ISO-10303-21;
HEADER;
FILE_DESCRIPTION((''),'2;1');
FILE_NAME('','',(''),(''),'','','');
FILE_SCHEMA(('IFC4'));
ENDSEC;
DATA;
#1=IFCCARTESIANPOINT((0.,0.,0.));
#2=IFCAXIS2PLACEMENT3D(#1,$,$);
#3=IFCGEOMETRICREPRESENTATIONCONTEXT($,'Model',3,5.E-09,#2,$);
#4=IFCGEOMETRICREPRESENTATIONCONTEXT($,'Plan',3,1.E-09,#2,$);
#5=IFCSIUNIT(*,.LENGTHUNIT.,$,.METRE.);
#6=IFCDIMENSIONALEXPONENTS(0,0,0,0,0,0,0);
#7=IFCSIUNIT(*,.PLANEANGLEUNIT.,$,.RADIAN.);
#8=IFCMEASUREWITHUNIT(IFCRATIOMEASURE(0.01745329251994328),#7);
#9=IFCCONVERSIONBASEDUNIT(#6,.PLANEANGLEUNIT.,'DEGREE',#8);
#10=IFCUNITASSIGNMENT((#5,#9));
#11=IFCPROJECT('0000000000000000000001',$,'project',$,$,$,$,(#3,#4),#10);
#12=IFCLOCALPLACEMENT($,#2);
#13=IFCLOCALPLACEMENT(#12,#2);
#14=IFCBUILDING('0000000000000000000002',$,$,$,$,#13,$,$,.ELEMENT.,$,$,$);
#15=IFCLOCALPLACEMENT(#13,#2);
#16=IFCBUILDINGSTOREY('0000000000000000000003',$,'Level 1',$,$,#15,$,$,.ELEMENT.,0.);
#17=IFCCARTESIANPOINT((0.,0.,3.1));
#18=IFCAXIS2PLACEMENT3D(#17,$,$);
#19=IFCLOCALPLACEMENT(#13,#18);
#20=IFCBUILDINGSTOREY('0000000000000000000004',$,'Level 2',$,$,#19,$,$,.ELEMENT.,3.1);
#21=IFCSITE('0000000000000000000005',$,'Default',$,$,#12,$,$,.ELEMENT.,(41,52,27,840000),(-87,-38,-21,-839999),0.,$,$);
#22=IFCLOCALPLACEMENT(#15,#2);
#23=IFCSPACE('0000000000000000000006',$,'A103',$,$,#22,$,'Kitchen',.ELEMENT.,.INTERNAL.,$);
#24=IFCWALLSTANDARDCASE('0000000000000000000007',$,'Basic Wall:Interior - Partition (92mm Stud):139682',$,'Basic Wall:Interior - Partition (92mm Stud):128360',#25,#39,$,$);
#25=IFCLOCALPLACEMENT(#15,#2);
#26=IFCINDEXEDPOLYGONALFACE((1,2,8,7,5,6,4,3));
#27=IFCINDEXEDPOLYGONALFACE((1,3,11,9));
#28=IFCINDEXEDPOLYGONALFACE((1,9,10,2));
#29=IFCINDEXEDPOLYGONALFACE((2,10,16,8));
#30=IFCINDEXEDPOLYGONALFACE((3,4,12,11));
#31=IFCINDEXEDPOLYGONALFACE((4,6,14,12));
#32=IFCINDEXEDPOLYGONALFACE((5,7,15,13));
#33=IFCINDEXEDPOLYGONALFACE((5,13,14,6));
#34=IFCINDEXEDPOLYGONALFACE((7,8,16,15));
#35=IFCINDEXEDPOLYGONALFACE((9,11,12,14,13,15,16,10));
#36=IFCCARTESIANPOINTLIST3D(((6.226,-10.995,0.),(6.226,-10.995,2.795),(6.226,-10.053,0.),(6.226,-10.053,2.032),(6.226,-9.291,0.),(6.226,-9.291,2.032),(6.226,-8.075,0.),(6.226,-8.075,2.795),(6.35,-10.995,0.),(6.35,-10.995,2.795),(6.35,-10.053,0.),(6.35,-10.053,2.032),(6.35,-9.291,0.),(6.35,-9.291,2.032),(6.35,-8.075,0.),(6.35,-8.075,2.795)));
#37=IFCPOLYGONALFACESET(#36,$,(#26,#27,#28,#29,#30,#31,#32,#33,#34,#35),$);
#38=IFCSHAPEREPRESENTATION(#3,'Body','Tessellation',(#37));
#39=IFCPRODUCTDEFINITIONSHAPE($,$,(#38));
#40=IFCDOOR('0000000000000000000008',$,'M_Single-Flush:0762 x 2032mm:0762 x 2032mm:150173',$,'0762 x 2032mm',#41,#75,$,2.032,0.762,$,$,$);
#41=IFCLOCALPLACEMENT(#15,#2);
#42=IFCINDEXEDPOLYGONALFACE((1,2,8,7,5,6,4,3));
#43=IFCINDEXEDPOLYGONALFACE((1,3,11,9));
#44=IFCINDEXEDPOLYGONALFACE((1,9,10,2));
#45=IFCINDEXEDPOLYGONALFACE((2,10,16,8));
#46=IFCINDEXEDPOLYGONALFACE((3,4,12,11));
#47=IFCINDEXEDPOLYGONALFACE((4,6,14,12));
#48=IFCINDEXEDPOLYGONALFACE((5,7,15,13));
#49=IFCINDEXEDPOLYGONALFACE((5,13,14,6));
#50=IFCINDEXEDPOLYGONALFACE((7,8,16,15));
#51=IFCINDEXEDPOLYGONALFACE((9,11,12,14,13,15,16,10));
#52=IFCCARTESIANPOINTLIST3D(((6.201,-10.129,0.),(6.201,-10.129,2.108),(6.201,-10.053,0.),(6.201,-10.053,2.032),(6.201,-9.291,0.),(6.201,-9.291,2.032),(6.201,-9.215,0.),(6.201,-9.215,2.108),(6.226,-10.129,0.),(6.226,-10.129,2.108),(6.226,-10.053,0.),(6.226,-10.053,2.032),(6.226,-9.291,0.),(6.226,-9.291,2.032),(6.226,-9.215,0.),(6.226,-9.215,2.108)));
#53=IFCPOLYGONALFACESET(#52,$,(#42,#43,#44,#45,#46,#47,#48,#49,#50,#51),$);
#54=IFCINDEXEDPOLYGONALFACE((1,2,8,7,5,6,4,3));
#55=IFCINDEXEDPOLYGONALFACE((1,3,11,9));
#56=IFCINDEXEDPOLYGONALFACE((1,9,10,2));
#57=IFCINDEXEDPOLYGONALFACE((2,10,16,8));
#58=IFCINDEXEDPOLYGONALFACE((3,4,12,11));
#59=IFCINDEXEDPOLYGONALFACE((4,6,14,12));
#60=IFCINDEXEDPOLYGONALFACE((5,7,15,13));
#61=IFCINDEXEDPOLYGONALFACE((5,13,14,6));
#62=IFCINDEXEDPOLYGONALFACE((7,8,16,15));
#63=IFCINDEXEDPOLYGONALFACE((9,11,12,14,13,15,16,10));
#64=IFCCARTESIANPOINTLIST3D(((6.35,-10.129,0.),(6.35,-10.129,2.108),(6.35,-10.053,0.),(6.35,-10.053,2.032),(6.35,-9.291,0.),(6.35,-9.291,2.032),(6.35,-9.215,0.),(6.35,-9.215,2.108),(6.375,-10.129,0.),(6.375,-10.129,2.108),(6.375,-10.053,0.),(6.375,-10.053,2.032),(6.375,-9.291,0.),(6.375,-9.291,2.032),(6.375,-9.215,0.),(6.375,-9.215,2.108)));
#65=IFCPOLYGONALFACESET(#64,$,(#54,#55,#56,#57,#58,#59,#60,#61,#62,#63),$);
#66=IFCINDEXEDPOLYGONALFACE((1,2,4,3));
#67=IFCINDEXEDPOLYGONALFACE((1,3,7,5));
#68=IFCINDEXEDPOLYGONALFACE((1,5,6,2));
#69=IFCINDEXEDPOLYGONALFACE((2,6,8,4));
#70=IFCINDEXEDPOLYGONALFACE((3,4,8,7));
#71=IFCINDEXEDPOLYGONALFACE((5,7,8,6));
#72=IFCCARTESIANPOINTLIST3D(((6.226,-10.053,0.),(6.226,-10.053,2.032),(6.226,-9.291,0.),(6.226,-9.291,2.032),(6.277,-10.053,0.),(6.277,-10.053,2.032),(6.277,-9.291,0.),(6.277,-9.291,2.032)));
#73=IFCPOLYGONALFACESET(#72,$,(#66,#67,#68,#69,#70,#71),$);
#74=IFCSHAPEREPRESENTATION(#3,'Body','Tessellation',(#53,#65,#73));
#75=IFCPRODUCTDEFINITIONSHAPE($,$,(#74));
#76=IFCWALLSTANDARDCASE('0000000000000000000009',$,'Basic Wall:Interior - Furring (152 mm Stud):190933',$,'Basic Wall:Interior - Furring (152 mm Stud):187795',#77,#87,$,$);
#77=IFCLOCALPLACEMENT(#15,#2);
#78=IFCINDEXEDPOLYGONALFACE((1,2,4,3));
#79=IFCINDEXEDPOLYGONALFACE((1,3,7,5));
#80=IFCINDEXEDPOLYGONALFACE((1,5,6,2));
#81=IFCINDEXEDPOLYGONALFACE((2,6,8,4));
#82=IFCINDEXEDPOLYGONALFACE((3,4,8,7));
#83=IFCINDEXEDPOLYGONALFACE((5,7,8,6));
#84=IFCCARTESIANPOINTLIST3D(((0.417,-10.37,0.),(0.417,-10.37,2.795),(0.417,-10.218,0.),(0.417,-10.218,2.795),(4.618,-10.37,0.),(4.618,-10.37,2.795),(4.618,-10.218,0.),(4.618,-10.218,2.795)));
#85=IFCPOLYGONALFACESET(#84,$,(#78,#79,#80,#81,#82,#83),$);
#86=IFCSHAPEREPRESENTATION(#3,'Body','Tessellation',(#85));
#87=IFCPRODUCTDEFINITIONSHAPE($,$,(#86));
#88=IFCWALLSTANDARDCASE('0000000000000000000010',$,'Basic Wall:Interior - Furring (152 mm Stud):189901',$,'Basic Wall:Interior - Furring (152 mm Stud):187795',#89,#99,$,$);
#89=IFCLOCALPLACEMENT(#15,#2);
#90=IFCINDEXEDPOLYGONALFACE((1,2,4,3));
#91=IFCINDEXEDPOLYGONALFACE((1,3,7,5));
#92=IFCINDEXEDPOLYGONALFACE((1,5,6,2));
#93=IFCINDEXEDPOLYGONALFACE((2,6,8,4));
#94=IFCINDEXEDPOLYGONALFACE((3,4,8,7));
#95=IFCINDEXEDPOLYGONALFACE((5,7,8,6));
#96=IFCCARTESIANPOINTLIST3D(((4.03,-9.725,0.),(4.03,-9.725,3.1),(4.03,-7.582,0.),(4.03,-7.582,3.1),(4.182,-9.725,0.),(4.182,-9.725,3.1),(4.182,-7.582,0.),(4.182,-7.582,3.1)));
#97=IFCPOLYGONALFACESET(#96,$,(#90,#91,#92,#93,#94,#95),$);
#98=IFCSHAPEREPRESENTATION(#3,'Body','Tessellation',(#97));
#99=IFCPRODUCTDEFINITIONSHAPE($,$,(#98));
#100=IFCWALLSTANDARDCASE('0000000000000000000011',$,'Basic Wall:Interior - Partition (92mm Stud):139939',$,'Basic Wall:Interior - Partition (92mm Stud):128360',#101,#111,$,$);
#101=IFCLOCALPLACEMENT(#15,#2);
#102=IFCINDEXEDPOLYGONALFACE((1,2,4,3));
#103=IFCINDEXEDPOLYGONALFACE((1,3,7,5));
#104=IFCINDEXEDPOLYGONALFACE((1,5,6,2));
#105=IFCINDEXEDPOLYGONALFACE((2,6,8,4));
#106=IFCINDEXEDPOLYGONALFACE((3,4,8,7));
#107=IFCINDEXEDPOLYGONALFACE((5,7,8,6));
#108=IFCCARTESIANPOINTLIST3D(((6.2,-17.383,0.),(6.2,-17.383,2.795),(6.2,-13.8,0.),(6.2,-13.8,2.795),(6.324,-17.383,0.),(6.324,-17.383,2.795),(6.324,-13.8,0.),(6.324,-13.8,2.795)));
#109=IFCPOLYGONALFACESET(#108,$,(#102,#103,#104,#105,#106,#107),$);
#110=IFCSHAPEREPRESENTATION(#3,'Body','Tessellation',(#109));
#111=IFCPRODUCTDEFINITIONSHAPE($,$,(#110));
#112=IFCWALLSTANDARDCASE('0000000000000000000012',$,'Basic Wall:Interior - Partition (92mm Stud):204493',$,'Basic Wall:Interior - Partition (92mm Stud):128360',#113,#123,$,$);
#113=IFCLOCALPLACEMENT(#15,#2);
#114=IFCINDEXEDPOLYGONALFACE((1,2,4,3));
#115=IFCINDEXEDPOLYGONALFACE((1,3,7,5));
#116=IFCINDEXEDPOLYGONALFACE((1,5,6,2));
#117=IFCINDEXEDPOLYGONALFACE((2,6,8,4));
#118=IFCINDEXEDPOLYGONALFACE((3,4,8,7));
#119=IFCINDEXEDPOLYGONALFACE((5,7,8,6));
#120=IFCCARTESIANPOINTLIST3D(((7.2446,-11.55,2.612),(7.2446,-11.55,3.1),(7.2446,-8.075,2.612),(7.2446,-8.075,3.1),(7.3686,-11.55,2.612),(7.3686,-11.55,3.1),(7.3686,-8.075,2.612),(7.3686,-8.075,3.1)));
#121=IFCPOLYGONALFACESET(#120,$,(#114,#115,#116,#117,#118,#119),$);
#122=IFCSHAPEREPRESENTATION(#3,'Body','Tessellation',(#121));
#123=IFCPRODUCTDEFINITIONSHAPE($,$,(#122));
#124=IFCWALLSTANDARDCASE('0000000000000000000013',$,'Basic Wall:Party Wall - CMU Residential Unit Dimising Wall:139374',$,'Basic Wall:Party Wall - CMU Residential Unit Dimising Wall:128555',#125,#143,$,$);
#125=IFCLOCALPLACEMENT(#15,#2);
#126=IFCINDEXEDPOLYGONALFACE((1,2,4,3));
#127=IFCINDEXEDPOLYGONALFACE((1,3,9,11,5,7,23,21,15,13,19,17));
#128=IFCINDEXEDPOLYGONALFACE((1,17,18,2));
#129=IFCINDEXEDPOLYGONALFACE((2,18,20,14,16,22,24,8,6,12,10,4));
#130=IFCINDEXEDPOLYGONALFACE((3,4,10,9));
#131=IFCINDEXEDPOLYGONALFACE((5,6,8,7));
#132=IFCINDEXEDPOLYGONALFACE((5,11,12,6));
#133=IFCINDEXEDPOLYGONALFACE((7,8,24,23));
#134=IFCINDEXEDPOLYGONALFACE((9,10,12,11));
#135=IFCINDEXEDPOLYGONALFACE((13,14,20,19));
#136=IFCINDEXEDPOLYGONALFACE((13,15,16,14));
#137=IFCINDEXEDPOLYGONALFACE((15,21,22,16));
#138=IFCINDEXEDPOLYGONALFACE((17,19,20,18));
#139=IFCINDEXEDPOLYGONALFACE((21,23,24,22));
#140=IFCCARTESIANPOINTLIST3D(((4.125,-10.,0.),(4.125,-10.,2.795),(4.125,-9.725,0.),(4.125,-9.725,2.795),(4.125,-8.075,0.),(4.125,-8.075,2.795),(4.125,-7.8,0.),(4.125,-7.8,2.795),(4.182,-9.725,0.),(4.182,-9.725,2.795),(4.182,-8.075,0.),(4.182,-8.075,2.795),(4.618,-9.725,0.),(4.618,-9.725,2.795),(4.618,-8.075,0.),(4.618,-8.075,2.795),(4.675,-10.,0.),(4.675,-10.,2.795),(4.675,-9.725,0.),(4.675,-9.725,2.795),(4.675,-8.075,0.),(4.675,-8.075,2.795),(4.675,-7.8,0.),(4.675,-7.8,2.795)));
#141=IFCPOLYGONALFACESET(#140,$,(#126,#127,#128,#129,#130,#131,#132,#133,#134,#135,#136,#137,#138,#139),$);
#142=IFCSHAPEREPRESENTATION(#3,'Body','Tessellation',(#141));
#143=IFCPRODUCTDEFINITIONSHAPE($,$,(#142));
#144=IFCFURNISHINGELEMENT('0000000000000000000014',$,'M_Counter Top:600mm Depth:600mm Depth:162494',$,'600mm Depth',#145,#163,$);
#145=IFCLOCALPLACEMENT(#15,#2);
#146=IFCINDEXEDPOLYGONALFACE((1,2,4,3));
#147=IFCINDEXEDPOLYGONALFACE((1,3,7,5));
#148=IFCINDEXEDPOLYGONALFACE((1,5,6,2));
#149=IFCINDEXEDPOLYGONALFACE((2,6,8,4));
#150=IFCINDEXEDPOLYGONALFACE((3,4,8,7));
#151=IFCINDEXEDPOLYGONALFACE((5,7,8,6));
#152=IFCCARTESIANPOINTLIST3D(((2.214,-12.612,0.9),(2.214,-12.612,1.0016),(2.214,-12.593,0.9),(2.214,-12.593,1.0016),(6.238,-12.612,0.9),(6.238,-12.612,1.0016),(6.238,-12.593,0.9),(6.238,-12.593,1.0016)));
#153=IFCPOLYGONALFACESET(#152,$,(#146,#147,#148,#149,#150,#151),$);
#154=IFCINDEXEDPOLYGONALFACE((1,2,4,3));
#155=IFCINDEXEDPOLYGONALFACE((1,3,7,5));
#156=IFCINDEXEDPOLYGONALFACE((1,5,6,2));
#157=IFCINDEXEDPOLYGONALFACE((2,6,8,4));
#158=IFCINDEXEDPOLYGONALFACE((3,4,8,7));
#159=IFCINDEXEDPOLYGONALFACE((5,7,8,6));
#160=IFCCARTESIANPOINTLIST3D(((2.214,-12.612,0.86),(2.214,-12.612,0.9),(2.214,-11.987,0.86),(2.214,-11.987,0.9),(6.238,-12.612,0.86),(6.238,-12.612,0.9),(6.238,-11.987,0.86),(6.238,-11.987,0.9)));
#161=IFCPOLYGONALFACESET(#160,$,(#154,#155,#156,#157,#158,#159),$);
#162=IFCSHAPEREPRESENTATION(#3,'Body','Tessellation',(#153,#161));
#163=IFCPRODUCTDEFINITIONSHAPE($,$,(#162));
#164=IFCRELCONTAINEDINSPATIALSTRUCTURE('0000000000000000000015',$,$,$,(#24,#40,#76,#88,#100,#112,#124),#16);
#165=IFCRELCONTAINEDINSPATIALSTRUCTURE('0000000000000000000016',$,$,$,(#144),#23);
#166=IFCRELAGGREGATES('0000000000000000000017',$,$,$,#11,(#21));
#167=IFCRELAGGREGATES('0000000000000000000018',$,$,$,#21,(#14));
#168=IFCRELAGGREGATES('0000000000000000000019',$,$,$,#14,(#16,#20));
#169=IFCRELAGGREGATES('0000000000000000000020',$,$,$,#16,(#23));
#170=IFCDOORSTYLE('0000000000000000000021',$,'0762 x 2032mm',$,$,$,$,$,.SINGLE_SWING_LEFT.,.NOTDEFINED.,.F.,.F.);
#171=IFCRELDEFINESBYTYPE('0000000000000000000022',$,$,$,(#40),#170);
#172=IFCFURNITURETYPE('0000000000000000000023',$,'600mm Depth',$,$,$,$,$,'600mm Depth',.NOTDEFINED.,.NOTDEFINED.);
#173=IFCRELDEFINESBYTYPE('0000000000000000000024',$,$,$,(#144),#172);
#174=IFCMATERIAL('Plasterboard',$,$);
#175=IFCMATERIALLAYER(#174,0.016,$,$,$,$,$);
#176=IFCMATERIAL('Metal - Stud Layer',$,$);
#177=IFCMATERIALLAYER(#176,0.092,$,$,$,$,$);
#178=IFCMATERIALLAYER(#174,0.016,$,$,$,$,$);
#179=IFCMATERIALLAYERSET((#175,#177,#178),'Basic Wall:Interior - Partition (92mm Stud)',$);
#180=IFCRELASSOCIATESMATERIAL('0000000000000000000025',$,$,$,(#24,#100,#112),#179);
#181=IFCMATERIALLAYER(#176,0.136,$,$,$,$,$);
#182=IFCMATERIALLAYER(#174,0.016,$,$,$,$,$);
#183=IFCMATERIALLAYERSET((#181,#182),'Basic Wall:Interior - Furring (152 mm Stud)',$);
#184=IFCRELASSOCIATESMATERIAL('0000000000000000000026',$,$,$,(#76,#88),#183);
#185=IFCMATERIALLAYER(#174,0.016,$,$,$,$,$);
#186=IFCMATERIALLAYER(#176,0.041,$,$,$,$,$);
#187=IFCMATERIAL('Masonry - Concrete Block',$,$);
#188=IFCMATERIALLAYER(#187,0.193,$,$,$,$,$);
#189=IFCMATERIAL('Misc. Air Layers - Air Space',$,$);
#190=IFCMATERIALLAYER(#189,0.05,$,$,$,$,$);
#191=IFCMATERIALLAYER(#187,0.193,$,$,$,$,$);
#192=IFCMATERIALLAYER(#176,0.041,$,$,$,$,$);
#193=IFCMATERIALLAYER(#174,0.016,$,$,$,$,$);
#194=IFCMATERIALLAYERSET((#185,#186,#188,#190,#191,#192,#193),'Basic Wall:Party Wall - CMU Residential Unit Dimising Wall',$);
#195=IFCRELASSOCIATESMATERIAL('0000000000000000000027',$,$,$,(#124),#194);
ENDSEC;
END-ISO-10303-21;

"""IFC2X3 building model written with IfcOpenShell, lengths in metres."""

from ifc_helpers import new_model, entity, si_unit, converted_unit, frame, frame_2d, origin, origin_2d_with_axis, place, context, project, spatial, polyline, rectangle, outline, extrude, clip, bounded_halfspace, source, transform, mapped, material, layer, layer_set, layer_usage, type_object, type_shapes, element, fill, save


model = new_model("IFC2X3")

# Units and contexts
model_context = context("Model", 3, precision=5e-09, world=origin())
plan_context = context("Plan", 3, precision=1e-09, world=origin())
ifc_project = project(units=[si_unit("LENGTHUNIT", "METRE"), converted_unit("PLANEANGLEUNIT", "DEGREE", entity("IfcRatioMeasure", 0.01745329251994328), si_unit("PLANEANGLEUNIT", "RADIAN"), dimensions=[0, 0, 0, 0, 0, 0, 0])], contexts=[model_context, plan_context])

# Site, building, storey
site_placement = place(None, origin())
site = spatial("IfcSite", under=ifc_project, at=site_placement, Name="Default", CompositionType="ELEMENT", RefLatitude=(41, 52, 27, 840000), RefLongitude=(-87, -38, -21, -839999), RefElevation=0.0)
building_placement = place(site_placement, origin())
building = spatial("IfcBuilding", under=site, at=building_placement, CompositionType="ELEMENT")
storey_1_placement = place(building_placement, origin())
storey_1 = spatial("IfcBuildingStorey", under=building, at=storey_1_placement, Name="Level 1", CompositionType="ELEMENT", Elevation=0.0)

# Shared definitions
ifc_material_1 = material(Name="Misc. Air Layers - Air Space")
ifc_material_2 = material(Name="Masonry - Concrete Block")
ifc_material_3 = material(Name="Metal - Stud Layer")
ifc_material_4 = material(Name="Plasterboard")

# Shared definitions
ifc_layer_1 = layer(ifc_material_4, 0.016)
ifc_layer_2 = layer(ifc_material_3, 0.041)
ifc_layer_3 = layer(ifc_material_2, 0.193)
ifc_layer_4 = layer(ifc_material_1, 0.05)
ifc_layer_5 = layer(ifc_material_2, 0.193)
ifc_layer_6 = layer(ifc_material_3, 0.041)
ifc_layer_7 = layer(ifc_material_4, 0.016)
ifc_layer_set_1 = layer_set([ifc_layer_1, ifc_layer_2, ifc_layer_3, ifc_layer_4, ifc_layer_5, ifc_layer_6, ifc_layer_7], Name="Basic Wall:Party Wall - CMU Residential Unit Dimising Wall")
ifc_layer_usage_1 = layer_usage(ifc_layer_set_1, "AXIS2", "NEGATIVE", 0.275)
ifc_layer_8 = layer(ifc_material_4, 0.016)
ifc_layer_9 = layer(ifc_material_3, 0.092)
ifc_layer_10 = layer(ifc_material_4, 0.016)
ifc_layer_set_2 = layer_set([ifc_layer_8, ifc_layer_9, ifc_layer_10], Name="Basic Wall:Interior - Partition (92mm Stud)")
ifc_layer_usage_2 = layer_usage(ifc_layer_set_2, "AXIS2", "NEGATIVE", 0.062)

# Shared definitions
storey_2_placement = place(building_placement, frame((0.0, 0.0, 3.1)))
storey_2 = spatial("IfcBuildingStorey", under=building, at=storey_2_placement, Name="Level 2", CompositionType="ELEMENT", Elevation=3.1)

# Wall, opening, door
wall_1_placement = place(storey_1_placement, frame((6.288, -10.995, 0.0), z_axis=(0.0, 0.0, 1.0), x_axis=(0.0, 1.0, 0.0)))
wall_1 = element("IfcWallStandardCase", 1, at=wall_1_placement, inside=storey_1, material=ifc_layer_usage_2, Name="Basic Wall:Interior - Partition (92mm Stud):139682", ObjectType="Basic Wall:Interior - Partition (92mm Stud):128360", context=model_context, shape_type="SweptSolid", body=[
    extrude(rectangle(XDim=2.92, YDim=0.124, at=frame_2d((1.46, 0.0), x_axis=(-1.0, 0.0))), origin(), (0.0, 0.0, 1.0), 2.795),
])
opening_1_placement = place(wall_1_placement, frame((0.942, -0.062, 0.0)))
opening_1 = element("IfcOpeningElement", 2, at=opening_1_placement, cuts=wall_1, ObjectType="Opening", context=model_context, shape_type="SweptSolid", body=[
    extrude(rectangle(XDim=0.762, YDim=2.032, at=frame_2d((1.016, 0.381), x_axis=(0.0, -1.0))), frame((0.0, 0.0, 0.0), z_axis=(0.0, 1.0, 0.0), x_axis=(0.0, 0.0, 1.0)), (0.0, 0.0, 1.0), 0.124),
])
door_style_1 = type_object("IfcDoorStyle", Name="0762 x 2032mm", ConstructionType="NOTDEFINED", OperationType="SINGLE_SWING_LEFT", ParameterTakesPrecedence=False, Sizeable=False)
shared_shape_1 = source(origin(), model_context, "Body", "SweptSolid", [
    extrude(outline(polyline([(-0.457, -1.073), (0.457, -1.073), (0.457, 1.035), (0.381, 1.035), (0.381, -0.997), (-0.381, -0.997), (-0.381, 1.035), (-0.457, 1.035), (-0.457, -1.073)])), frame((0.381, 0.149, 1.035), z_axis=(0.0, -1.0, 0.0), x_axis=(-1.0, 0.0, 0.0)), (0.0, 0.0, 1.0), 0.025),
    extrude(outline(polyline([(-1.073, -0.457), (1.035, -0.457), (1.035, -0.381), (-0.997, -0.381), (-0.997, 0.381), (1.035, 0.381), (1.035, 0.457), (-1.073, 0.457), (-1.073, -0.457)])), frame((0.381, 0.0, 1.035), z_axis=(0.0, -1.0, 0.0), x_axis=(0.0, 0.0, -1.0)), (0.0, 0.0, 1.0), 0.025),
    extrude(rectangle(XDim=0.762, YDim=0.051, at=origin_2d_with_axis()), frame((0.381, 0.0985, 0.0)), (0.0, 0.0, 1.0), 2.032),
])
type_shapes(door_style_1, [shared_shape_1])
door_1_placement = place(opening_1_placement, origin())
door_1 = element("IfcDoor", 3, at=door_1_placement, inside=storey_1, type_object=door_style_1, Name="M_Single-Flush:0762 x 2032mm:0762 x 2032mm:150173", ObjectType="0762 x 2032mm", OverallHeight=2.032, OverallWidth=0.762, context=model_context, shape_type="MappedRepresentation", body=[
    mapped(shared_shape_1, transform((0.0, 0.0, 0.0), scale=1.0)),
])
fill(opening_1, door_1)

# Walls
ifc_layer_11 = layer(ifc_material_3, 0.136)
ifc_layer_12 = layer(ifc_material_4, 0.016)
ifc_layer_set_3 = layer_set([ifc_layer_11, ifc_layer_12], Name="Basic Wall:Interior - Furring (152 mm Stud)")
ifc_layer_usage_3 = layer_usage(ifc_layer_set_3, "AXIS2", "NEGATIVE", 0.076)
wall_2_placement = place(storey_1_placement, frame((0.417, -10.294, 0.0)))
element("IfcWallStandardCase", 4, at=wall_2_placement, inside=storey_1, material=ifc_layer_usage_3, Name="Basic Wall:Interior - Furring (152 mm Stud):190933", ObjectType="Basic Wall:Interior - Furring (152 mm Stud):187795", context=model_context, shape_type="SweptSolid", body=[
    extrude(rectangle(XDim=4.201, YDim=0.152, at=frame_2d((2.1005, 0.0), x_axis=(-1.0, 0.0))), origin(), (0.0, 0.0, 1.0), 2.795),
])
ifc_layer_usage_4 = layer_usage(ifc_layer_set_3, "AXIS2", "POSITIVE", -0.076)
wall_3_placement = place(storey_1_placement, frame((4.106, -9.725, 0.0), z_axis=(0.0, 0.0, 1.0), x_axis=(0.0, 1.0, 0.0)))
element("IfcWallStandardCase", 5, at=wall_3_placement, inside=storey_1, material=ifc_layer_usage_4, Name="Basic Wall:Interior - Furring (152 mm Stud):189901", ObjectType="Basic Wall:Interior - Furring (152 mm Stud):187795", context=model_context, shape_type="SweptSolid", body=[
    extrude(rectangle(XDim=2.143, YDim=0.152, at=frame_2d((1.0715, 0.0), x_axis=(-1.0, 0.0))), origin(), (0.0, 0.0, 1.0), 3.1),
])
wall_4_placement = place(storey_1_placement, frame((6.262, -13.8, 0.0), z_axis=(0.0, 0.0, 1.0), x_axis=(0.0, -1.0, 0.0)))
element("IfcWallStandardCase", 6, at=wall_4_placement, inside=storey_1, material=ifc_layer_usage_2, Name="Basic Wall:Interior - Partition (92mm Stud):139939", ObjectType="Basic Wall:Interior - Partition (92mm Stud):128360", context=model_context, shape_type="SweptSolid", body=[
    extrude(rectangle(XDim=3.583, YDim=0.124, at=frame_2d((1.7915, 0.0), x_axis=(-1.0, 0.0))), origin(), (0.0, 0.0, 1.0), 2.795),
])
wall_5_placement = place(storey_1_placement, frame((7.3066, -11.55, 2.612), z_axis=(0.0, 0.0, 1.0), x_axis=(0.0, 1.0, 0.0)))
element("IfcWallStandardCase", 7, at=wall_5_placement, inside=storey_1, material=ifc_layer_usage_2, Name="Basic Wall:Interior - Partition (92mm Stud):204493", ObjectType="Basic Wall:Interior - Partition (92mm Stud):128360", context=model_context, shape_type="SweptSolid", body=[
    extrude(rectangle(XDim=3.475, YDim=0.124, at=frame_2d((1.7375, 0.0), x_axis=(-1.0, 0.0))), origin(), (0.0, 0.0, 1.0), 0.488),
])
wall_6_placement = place(storey_1_placement, frame((4.4, -10.0, 0.0), z_axis=(0.0, 0.0, 1.0), x_axis=(0.0, 1.0, 0.0)))
element("IfcWallStandardCase", 8, at=wall_6_placement, inside=storey_1, material=ifc_layer_usage_1, Name="Basic Wall:Party Wall - CMU Residential Unit Dimising Wall:139374", ObjectType="Basic Wall:Party Wall - CMU Residential Unit Dimising Wall:128555", context=model_context, shape_type="Clipping", body=[
    clip(clip(extrude(rectangle(XDim=2.2, YDim=0.55, at=frame_2d((1.1, 0.0), x_axis=(-1.0, 0.0))), origin(), (0.0, 0.0, 1.0), 2.795), bounded_halfspace(frame((1.925, 0.218, 0.0), z_axis=(0.0, -1.0, 0.0), x_axis=(1.0, 0.0, 0.0)), True, frame((1.925, 0.218, 0.0), z_axis=(0.0, -1.0, 0.0), x_axis=(1.0, 0.0, 0.0)), polyline([(0.0, 0.0), (0.0, 2.795), (-1.65, 2.795), (-1.65, 0.0), (0.0, 0.0)]))), bounded_halfspace(frame((0.275, -0.218, 0.0), z_axis=(0.0, 1.0, 0.0), x_axis=(-1.0, 0.0, 0.0)), True, frame((0.275, -0.218, 0.0), z_axis=(0.0, 1.0, 0.0), x_axis=(-1.0, 0.0, 0.0)), polyline([(0.0, 0.0), (0.0, 2.795), (-1.65, 2.795), (-1.65, 0.0), (0.0, 0.0)]))),
])

# Shared definitions
space_1_placement = place(storey_1_placement, origin())
space_1 = spatial("IfcSpace", under=storey_1, at=space_1_placement, Name="A103", LongName="Kitchen", CompositionType="ELEMENT", InteriorOrExteriorSpace="INTERNAL")

# Furnishing element
furniture_type_1 = type_object("IfcFurnitureType", Name="600mm Depth", ElementType="600mm Depth", AssemblyPlace="NOTDEFINED")
shared_shape_2 = source(origin(), model_context, "Body", "SweptSolid", [
    extrude(rectangle(XDim=0.0191, YDim=4.024, at=origin_2d_with_axis()), frame((0.8115, -0.0095, 0.9), z_axis=(0.0, 0.0, 1.0), x_axis=(0.0, -1.0, 0.0)), (0.0, 0.0, 1.0), 0.1016),
    extrude(rectangle(XDim=4.024, YDim=0.625, at=origin_2d_with_axis()), frame((0.8115, -0.3125, 0.86), z_axis=(0.0, 0.0, 1.0), x_axis=(-1.0, 0.0, 0.0)), (0.0, 0.0, 1.0), 0.04),
])
type_shapes(furniture_type_1, [shared_shape_2])
furnishing_1_placement = place(space_1_placement, frame((5.0375, -12.612, 0.0), z_axis=(0.0, 0.0, 1.0), x_axis=(-1.0, 0.0, 0.0)))
element("IfcFurnishingElement", 9, at=furnishing_1_placement, inside=space_1, type_object=furniture_type_1, Name="M_Counter Top:600mm Depth:600mm Depth:162494", ObjectType="600mm Depth", context=model_context, shape_type="MappedRepresentation", body=[
    mapped(shared_shape_2, transform((0.0, 0.0, 0.0), scale=1.0)),
])

save(model, "model.ifc")
